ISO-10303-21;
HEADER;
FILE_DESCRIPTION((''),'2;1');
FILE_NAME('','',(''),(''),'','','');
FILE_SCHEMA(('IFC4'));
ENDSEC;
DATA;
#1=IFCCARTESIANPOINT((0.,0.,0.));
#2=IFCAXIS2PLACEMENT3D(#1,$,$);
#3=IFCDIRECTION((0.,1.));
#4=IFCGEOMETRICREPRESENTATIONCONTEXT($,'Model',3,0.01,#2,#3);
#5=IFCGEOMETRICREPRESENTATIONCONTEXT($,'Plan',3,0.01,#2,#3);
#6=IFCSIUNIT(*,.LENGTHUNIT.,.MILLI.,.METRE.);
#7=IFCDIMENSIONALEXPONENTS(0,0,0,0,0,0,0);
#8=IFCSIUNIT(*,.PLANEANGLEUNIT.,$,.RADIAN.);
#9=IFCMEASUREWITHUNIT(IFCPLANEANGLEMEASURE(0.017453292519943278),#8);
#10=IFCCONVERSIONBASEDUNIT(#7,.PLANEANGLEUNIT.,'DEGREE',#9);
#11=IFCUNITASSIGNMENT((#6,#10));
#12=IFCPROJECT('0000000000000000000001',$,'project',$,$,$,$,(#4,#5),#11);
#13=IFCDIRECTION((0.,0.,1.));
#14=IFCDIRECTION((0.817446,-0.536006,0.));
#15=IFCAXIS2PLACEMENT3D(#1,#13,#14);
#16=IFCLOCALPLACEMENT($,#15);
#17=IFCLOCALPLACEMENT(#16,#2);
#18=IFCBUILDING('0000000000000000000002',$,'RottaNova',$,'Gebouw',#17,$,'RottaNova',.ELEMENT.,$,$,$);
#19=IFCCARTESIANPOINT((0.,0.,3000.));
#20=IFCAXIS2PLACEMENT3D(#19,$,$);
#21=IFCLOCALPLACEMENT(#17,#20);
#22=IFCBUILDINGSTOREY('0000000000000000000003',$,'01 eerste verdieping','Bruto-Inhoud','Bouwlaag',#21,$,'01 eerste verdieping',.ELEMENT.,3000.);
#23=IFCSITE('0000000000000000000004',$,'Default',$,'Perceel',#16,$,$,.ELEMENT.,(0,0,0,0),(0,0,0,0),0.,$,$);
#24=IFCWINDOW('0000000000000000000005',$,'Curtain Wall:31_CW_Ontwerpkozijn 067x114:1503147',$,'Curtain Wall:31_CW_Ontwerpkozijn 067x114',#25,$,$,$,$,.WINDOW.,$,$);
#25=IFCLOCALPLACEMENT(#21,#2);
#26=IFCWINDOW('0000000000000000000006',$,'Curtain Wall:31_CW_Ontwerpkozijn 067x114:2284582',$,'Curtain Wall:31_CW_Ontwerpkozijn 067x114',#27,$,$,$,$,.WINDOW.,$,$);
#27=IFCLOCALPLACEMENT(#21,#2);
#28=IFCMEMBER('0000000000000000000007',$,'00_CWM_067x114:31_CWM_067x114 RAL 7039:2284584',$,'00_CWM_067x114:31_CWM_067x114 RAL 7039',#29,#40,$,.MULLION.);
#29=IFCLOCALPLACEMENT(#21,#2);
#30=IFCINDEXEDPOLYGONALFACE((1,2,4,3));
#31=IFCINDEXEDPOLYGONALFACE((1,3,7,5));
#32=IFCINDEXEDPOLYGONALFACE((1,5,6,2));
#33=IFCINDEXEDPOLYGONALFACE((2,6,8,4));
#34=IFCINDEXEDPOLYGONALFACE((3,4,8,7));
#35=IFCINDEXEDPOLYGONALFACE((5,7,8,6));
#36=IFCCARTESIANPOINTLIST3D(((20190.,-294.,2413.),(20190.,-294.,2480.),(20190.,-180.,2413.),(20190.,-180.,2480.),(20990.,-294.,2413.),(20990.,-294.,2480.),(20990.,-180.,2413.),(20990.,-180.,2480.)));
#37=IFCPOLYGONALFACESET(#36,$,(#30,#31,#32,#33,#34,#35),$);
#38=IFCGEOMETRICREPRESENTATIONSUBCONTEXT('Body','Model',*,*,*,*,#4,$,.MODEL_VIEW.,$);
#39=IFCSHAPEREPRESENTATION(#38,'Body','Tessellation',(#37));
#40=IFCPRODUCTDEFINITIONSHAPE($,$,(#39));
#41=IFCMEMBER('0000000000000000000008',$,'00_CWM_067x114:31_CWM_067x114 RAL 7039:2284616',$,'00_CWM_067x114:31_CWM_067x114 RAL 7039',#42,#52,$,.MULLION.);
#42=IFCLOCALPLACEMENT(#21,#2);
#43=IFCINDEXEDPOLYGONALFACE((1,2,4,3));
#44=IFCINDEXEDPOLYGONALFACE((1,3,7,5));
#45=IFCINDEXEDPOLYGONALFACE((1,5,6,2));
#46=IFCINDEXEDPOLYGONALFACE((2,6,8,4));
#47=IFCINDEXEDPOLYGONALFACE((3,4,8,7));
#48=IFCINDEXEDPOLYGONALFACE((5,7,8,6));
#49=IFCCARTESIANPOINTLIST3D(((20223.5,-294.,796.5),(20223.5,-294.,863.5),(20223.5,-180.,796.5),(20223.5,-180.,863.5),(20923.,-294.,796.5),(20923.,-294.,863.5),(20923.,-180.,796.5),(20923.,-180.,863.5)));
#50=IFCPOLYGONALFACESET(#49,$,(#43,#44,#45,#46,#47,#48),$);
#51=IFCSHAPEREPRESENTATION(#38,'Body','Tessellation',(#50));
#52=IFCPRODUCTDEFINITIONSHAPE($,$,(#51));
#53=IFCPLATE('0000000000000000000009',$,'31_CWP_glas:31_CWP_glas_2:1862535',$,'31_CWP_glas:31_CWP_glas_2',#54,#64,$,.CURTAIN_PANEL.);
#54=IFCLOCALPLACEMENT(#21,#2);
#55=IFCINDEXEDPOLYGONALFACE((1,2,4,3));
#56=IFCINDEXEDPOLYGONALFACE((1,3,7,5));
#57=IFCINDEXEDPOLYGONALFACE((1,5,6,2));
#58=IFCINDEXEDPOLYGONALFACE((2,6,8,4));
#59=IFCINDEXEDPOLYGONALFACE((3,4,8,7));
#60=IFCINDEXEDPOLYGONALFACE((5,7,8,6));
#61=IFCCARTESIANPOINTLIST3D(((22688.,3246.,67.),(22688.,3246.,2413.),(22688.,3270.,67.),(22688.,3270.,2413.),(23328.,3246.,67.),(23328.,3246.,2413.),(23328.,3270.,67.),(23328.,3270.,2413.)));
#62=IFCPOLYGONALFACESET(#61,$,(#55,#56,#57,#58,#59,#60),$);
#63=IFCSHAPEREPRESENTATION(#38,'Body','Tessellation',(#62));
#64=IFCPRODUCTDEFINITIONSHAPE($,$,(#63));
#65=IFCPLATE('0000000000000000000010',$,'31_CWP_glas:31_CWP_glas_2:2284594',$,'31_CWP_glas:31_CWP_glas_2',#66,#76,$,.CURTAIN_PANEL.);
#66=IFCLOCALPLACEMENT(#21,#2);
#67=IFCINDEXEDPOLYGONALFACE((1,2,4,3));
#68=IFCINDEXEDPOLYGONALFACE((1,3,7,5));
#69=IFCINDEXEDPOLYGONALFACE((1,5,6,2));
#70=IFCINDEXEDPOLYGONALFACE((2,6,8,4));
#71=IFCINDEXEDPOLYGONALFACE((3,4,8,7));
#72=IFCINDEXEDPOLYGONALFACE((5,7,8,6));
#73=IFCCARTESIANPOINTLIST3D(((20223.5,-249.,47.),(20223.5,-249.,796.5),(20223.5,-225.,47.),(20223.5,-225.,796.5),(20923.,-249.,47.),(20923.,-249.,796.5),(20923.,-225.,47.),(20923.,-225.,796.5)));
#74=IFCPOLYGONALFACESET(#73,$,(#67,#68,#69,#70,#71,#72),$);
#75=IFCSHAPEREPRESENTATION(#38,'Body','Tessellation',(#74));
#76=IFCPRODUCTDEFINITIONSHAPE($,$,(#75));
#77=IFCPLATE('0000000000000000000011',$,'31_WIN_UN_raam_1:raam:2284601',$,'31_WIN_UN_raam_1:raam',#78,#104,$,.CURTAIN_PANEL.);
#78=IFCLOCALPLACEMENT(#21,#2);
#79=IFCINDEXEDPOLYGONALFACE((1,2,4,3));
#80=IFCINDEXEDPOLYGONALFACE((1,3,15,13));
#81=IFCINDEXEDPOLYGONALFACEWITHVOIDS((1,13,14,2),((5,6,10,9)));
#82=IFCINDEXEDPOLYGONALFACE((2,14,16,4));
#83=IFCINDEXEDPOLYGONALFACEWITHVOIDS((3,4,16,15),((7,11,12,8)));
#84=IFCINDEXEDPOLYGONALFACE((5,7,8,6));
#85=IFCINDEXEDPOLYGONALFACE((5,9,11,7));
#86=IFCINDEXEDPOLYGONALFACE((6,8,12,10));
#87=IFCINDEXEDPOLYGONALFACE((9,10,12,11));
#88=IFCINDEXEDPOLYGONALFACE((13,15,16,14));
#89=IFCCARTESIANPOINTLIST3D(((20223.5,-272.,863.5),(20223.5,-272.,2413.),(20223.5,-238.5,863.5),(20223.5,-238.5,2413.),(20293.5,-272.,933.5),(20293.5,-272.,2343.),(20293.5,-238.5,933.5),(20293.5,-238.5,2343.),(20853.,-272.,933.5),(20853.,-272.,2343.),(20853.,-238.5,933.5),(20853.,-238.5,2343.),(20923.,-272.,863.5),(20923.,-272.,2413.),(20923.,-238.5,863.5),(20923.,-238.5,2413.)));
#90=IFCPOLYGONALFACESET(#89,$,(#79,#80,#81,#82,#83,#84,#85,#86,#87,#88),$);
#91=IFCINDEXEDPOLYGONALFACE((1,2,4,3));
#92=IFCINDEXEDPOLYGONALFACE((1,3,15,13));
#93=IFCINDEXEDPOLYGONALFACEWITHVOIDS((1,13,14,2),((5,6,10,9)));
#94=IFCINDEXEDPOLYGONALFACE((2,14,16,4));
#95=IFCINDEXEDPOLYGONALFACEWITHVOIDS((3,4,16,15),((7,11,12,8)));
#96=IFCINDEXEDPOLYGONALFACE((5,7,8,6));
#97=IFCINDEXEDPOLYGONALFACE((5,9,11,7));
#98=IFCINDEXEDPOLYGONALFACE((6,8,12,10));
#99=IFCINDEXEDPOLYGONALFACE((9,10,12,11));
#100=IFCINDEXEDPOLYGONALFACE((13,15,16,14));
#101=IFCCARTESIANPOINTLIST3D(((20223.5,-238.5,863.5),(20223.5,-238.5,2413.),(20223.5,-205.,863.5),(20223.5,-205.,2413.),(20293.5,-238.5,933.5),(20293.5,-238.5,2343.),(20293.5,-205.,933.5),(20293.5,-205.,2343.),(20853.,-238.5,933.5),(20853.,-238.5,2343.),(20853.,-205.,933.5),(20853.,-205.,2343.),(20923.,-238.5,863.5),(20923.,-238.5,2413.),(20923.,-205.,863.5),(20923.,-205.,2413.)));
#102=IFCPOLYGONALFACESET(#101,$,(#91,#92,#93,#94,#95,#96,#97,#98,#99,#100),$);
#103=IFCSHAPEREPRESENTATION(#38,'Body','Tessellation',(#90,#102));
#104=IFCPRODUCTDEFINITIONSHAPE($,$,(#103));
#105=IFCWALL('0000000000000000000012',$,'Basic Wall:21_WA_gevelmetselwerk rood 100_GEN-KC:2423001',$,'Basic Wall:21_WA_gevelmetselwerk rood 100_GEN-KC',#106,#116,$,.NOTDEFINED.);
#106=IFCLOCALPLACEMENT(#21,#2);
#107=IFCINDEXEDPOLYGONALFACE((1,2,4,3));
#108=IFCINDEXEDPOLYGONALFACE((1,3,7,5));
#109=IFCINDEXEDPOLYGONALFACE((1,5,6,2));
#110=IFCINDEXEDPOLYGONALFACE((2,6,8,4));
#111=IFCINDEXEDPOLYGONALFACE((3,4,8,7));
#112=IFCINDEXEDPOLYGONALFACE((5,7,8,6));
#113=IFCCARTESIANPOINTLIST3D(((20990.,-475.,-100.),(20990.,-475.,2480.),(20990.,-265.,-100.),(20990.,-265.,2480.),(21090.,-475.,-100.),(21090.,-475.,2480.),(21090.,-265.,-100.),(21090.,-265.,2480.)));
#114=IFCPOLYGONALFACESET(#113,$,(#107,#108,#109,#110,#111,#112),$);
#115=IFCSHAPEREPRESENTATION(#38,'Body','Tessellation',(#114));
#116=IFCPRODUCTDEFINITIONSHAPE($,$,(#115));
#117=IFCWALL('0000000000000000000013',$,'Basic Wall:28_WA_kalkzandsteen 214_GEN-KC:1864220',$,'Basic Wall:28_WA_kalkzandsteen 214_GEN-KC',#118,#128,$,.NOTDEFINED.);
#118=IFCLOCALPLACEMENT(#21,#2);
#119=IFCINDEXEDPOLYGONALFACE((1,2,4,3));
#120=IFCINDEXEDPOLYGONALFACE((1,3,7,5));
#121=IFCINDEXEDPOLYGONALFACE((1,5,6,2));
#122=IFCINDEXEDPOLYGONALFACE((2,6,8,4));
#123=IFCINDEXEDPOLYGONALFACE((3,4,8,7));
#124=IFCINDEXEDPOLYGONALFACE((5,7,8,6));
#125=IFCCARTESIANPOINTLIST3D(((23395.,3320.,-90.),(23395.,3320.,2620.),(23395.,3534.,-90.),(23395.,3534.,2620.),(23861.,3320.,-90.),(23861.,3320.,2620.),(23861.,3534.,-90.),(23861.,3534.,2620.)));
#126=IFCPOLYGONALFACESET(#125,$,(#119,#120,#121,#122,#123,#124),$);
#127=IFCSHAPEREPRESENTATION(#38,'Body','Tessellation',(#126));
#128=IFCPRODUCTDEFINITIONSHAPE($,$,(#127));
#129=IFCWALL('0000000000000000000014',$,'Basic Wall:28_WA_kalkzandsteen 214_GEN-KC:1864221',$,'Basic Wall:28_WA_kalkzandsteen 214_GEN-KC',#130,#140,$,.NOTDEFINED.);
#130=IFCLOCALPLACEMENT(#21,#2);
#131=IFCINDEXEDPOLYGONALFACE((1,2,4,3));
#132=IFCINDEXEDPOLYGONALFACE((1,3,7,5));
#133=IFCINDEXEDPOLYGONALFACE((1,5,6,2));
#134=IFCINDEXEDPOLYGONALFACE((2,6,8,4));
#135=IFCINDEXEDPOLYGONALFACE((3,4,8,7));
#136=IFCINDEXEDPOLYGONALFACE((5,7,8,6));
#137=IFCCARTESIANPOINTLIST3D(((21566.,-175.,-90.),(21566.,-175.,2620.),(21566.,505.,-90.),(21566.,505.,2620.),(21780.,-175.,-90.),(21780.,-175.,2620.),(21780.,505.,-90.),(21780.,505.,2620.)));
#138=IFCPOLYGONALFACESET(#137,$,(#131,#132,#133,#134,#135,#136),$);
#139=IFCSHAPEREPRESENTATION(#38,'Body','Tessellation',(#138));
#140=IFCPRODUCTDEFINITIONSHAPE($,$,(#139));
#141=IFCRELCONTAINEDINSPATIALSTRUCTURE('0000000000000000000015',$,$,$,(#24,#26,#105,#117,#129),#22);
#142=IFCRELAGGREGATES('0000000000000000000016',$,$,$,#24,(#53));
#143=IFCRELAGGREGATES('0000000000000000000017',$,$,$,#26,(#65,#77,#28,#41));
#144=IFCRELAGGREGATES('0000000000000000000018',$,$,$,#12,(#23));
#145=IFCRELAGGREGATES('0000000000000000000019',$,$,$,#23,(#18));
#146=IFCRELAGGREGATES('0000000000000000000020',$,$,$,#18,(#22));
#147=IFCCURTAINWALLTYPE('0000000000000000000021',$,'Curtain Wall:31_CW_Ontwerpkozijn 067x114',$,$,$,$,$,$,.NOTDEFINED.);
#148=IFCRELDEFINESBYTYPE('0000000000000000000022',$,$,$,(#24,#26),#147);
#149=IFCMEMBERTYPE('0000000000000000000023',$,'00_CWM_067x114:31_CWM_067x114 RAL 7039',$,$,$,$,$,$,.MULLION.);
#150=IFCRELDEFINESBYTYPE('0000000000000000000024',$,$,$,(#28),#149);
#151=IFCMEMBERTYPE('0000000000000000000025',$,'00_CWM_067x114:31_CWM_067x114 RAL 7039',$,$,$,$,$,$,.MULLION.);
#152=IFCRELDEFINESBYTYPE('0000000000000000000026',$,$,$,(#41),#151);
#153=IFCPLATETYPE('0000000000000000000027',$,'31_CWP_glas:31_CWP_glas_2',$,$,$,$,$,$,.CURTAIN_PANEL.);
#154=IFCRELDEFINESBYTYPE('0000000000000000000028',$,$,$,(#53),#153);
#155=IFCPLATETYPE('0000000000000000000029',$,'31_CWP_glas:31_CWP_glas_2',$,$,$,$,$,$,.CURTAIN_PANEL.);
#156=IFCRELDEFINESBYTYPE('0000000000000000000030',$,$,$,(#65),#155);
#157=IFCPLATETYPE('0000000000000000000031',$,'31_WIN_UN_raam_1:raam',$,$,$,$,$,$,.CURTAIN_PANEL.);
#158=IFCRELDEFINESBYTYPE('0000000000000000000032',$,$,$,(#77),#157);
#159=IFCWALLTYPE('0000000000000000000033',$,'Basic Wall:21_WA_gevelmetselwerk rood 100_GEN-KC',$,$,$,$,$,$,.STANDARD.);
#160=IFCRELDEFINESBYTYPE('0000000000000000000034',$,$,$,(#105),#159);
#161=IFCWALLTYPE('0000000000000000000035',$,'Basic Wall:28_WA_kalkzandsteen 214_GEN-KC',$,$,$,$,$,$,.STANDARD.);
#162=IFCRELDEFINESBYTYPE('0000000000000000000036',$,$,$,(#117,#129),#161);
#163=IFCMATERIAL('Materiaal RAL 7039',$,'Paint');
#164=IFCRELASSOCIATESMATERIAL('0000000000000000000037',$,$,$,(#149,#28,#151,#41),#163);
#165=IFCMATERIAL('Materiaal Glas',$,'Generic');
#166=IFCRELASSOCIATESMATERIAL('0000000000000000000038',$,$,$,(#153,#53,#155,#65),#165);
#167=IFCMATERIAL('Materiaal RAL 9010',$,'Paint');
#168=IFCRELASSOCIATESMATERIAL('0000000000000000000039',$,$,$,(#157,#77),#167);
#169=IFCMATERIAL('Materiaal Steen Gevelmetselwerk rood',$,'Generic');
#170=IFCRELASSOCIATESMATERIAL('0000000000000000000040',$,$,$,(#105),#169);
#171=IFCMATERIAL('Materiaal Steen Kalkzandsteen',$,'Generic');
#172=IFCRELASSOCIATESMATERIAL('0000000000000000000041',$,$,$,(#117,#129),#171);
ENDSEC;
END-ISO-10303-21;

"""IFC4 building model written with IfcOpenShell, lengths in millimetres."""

from ifc_helpers import new_model, entity, si_unit, converted_unit, direction, frame, origin, place, context, subcontext, project, spatial, indexed_curve, outline, extrude, source, transform, mapped, material, type_object, type_shapes, element, aggregate, save


model = new_model("IFC4")

# Units and contexts
model_context = context("Model", 3, precision=0.01, world=origin(), true_north=direction((0.0, 1.0)))
plan_context = context("Plan", 3, precision=0.01, world=origin(), true_north=direction((0.0, 1.0)))
body_context = subcontext(model_context, "Body", "Model", "MODEL_VIEW")
ifc_project = project(units=[si_unit("LENGTHUNIT", "METRE", prefix="MILLI"), converted_unit("PLANEANGLEUNIT", "DEGREE", entity("IfcPlaneAngleMeasure", 0.017453292519943278), si_unit("PLANEANGLEUNIT", "RADIAN"), dimensions=[0, 0, 0, 0, 0, 0, 0])], contexts=[model_context, plan_context])

# Site, building, storey
site_placement = place(None, frame((0.0, 0.0, 0.0), z_axis=(0.0, 0.0, 1.0), x_axis=(0.817446, -0.536006, 0.0)))
site = spatial("IfcSite", under=ifc_project, at=site_placement, Name="Default", ObjectType="Perceel", CompositionType="ELEMENT", RefLatitude=(0, 0, 0, 0), RefLongitude=(0, 0, 0, 0), RefElevation=0.0)
building_placement = place(site_placement, origin())
building = spatial("IfcBuilding", under=site, at=building_placement, Name="RottaNova", ObjectType="Gebouw", LongName="RottaNova", CompositionType="ELEMENT")
storey_placement = place(building_placement, frame((0.0, 0.0, 3000.0)))
storey = spatial("IfcBuildingStorey", under=building, at=storey_placement, Name="01 eerste verdieping", Description="Bruto-Inhoud", ObjectType="Bouwlaag", LongName="01 eerste verdieping", CompositionType="ELEMENT", Elevation=3000.0)

# Windows, members
curtain_wall_type = type_object("IfcCurtainWallType", Name="Curtain Wall:31_CW_Ontwerpkozijn 067x114", PredefinedType="NOTDEFINED")
ifc_material_1 = material(Name="Materiaal RAL 7039", Category="Paint")
window_1_placement = place(storey_placement, frame((0.0, 0.0, -3000.0)))
window_1 = element("IfcWindow", 1, at=window_1_placement, inside=storey, type_object=curtain_wall_type, Name="Curtain Wall:31_CW_Ontwerpkozijn 067x114:1503147", ObjectType="Curtain Wall:31_CW_Ontwerpkozijn 067x114", PredefinedType="WINDOW")
window_2_placement = place(storey_placement, frame((0.0, 0.0, -3000.0)))
window_2 = element("IfcWindow", 2, at=window_2_placement, inside=storey, type_object=curtain_wall_type, Name="Curtain Wall:31_CW_Ontwerpkozijn 067x114:2284582", ObjectType="Curtain Wall:31_CW_Ontwerpkozijn 067x114", PredefinedType="WINDOW")
member_type_1 = type_object("IfcMemberType", Name="00_CWM_067x114:31_CWM_067x114 RAL 7039", PredefinedType="MULLION", material=ifc_material_1)
shared_shape_1 = source(origin(), body_context, "Body", "SweptSolid", [
    extrude(outline(indexed_curve([(-33.5, -57.0), (33.5, -57.0), (33.5, 57.0), (-33.5, 57.0), (-33.5, -57.0)], self_intersect=False)), frame((-33.5, 57.0, -800.0), z_axis=(0.0, 0.0, 1.0), x_axis=(-1.0, 0.0, 0.0)), (0.0, 0.0, 1.0), 800.0),
])
type_shapes(member_type_1, [shared_shape_1])
member_1_placement = place(window_2_placement, frame((20990.0, -180.0, 5480.0), z_axis=(1.0, 0.0, 0.0), x_axis=(0.0, 0.0, 1.0)))
member_1 = element("IfcMember", 3, at=member_1_placement, type_object=member_type_1, material=ifc_material_1, Name="00_CWM_067x114:31_CWM_067x114 RAL 7039:2284584", ObjectType="00_CWM_067x114:31_CWM_067x114 RAL 7039", PredefinedType="MULLION", context=body_context, shape_type="MappedRepresentation", body=[
    mapped(shared_shape_1, transform((0.0, 0.0, 0.0), scale=1.0)),
])
member_type_2 = type_object("IfcMemberType", Name="00_CWM_067x114:31_CWM_067x114 RAL 7039", PredefinedType="MULLION", material=ifc_material_1)
shared_shape_2 = source(origin(), body_context, "Body", "SweptSolid", [
    extrude(outline(indexed_curve([(-33.5, -57.0), (33.5, -57.0), (33.5, 57.0), (-33.5, 57.0), (-33.5, -57.0)], self_intersect=False)), frame((0.0, 57.0, -699.5), z_axis=(0.0, 0.0, 1.0), x_axis=(-1.0, 0.0, 0.0)), (0.0, 0.0, 1.0), 699.5),
])
type_shapes(member_type_2, [shared_shape_2])
member_2_placement = place(window_2_placement, frame((20923.0, -180.0, 3830.0), z_axis=(1.0, 0.0, 0.0), x_axis=(0.0, 0.0, 1.0)))
member_2 = element("IfcMember", 4, at=member_2_placement, type_object=member_type_2, material=ifc_material_1, Name="00_CWM_067x114:31_CWM_067x114 RAL 7039:2284616", ObjectType="00_CWM_067x114:31_CWM_067x114 RAL 7039", PredefinedType="MULLION", context=body_context, shape_type="MappedRepresentation", body=[
    mapped(shared_shape_2, transform((0.0, 0.0, 0.0), scale=1.0)),
])

# Plates
ifc_material_2 = material(Name="Materiaal Glas", Category="Generic")
plate_type_1 = type_object("IfcPlateType", Name="31_CWP_glas:31_CWP_glas_2", PredefinedType="CURTAIN_PANEL", material=ifc_material_2)
shared_shape_3 = source(origin(), body_context, "Body", "SweptSolid", [
    extrude(outline(indexed_curve([(-12.0, -320.0), (12.0, -320.0), (12.0, 320.0), (-12.0, 320.0), (-12.0, -320.0)], self_intersect=False)), frame((0.0, -57.0, 0.0), z_axis=(0.0, 0.0, 1.0), x_axis=(0.0, 1.0, 0.0)), (0.0, 0.0, 1.0), 2346.0),
])
type_shapes(plate_type_1, [shared_shape_3])
plate_1_placement = place(window_1_placement, frame((23008.0, 3315.0, 3067.0)))
plate_1 = element("IfcPlate", 5, at=plate_1_placement, type_object=plate_type_1, material=ifc_material_2, Name="31_CWP_glas:31_CWP_glas_2:1862535", ObjectType="31_CWP_glas:31_CWP_glas_2", PredefinedType="CURTAIN_PANEL", context=body_context, shape_type="MappedRepresentation", body=[
    mapped(shared_shape_3, transform((0.0, 0.0, 0.0), scale=1.0)),
])
aggregate(window_1, [plate_1])
plate_type_2 = type_object("IfcPlateType", Name="31_CWP_glas:31_CWP_glas_2", PredefinedType="CURTAIN_PANEL", material=ifc_material_2)
shared_shape_4 = source(origin(), body_context, "Body", "SweptSolid", [
    extrude(outline(indexed_curve([(-12.0, -349.7), (12.0, -349.7), (12.0, 349.7), (-12.0, 349.7), (-12.0, -349.7)], self_intersect=False)), frame((0.0, -57.0, 0.0), z_axis=(0.0, 0.0, 1.0), x_axis=(0.0, 1.0, 0.0)), (0.0, 0.0, 1.0), 749.5),
])
type_shapes(plate_type_2, [shared_shape_4])
plate_2_placement = place(window_2_placement, frame((20573.3, -180.0, 3047.0)))
plate_2 = element("IfcPlate", 6, at=plate_2_placement, type_object=plate_type_2, material=ifc_material_2, Name="31_CWP_glas:31_CWP_glas_2:2284594", ObjectType="31_CWP_glas:31_CWP_glas_2", PredefinedType="CURTAIN_PANEL", context=body_context, shape_type="MappedRepresentation", body=[
    mapped(shared_shape_4, transform((0.0, 0.0, 0.0), scale=1.0)),
])
ifc_material_3 = material(Name="Materiaal RAL 9010", Category="Paint")
plate_type_3 = type_object("IfcPlateType", Name="31_WIN_UN_raam_1:raam", PredefinedType="CURTAIN_PANEL", material=ifc_material_3)
shared_shape_5 = source(origin(), body_context, "Body", "SweptSolid", [
    extrude(outline(indexed_curve([(-349.7, -774.8), (349.7, -774.8), (349.7, 774.8), (-349.7, 774.8), (-349.7, -774.8)], self_intersect=False), holes=[indexed_curve([(-279.7, 704.8), (279.7, 704.8), (279.7, -704.8), (-279.7, -704.8), (-279.7, 704.8)], self_intersect=False)]), frame((0.0, -92.0, 774.8), z_axis=(0.0, 1.0, 0.0), x_axis=(1.0, 0.0, 0.0)), (0.0, 0.0, 1.0), 33.5),
    extrude(outline(indexed_curve([(-349.7, -774.8), (349.7, -774.8), (349.7, 774.8), (-349.7, 774.8), (-349.7, -774.8)], self_intersect=False), holes=[indexed_curve([(-279.7, 704.7), (279.7, 704.7), (279.7, -704.8), (-279.7, -704.8), (-279.7, 704.7)], self_intersect=False)]), frame((0.0, -58.5, 774.8), z_axis=(0.0, 1.0, 0.0), x_axis=(1.0, 0.0, 0.0)), (0.0, 0.0, 1.0), 33.5),
])
type_shapes(plate_type_3, [shared_shape_5])
plate_3_placement = place(window_2_placement, frame((20573.3, -180.0, 3863.5)))
plate_3 = element("IfcPlate", 7, at=plate_3_placement, type_object=plate_type_3, material=ifc_material_3, Name="31_WIN_UN_raam_1:raam:2284601", ObjectType="31_WIN_UN_raam_1:raam", PredefinedType="CURTAIN_PANEL", context=body_context, shape_type="MappedRepresentation", body=[
    mapped(shared_shape_5, transform((0.0, 0.0, 0.0), scale=1.0)),
])
aggregate(window_2, [plate_2, plate_3, member_1, member_2])

# Walls
ifc_material_4 = material(Name="Materiaal Steen Gevelmetselwerk rood", Category="Generic")
wall_type_1 = type_object("IfcWallType", Name="Basic Wall:21_WA_gevelmetselwerk rood 100_GEN-KC", PredefinedType="STANDARD")
wall_1_placement = place(storey_placement, frame((21040.0, -265.0, -100.0), z_axis=(0.0, 0.0, 1.0), x_axis=(0.0, -1.0, 0.0)))
element("IfcWall", 8, at=wall_1_placement, inside=storey, type_object=wall_type_1, material=ifc_material_4, Name="Basic Wall:21_WA_gevelmetselwerk rood 100_GEN-KC:2423001", ObjectType="Basic Wall:21_WA_gevelmetselwerk rood 100_GEN-KC", PredefinedType="NOTDEFINED", context=body_context, shape_type="SweptSolid", body=[
    extrude(outline(indexed_curve([(210.0, 50.0), (0.0, 50.0), (0.0, -50.0), (210.0, -50.0), (210.0, 50.0)], self_intersect=False)), origin(), (0.0, 0.0, 1.0), 2580.0),
])
ifc_material_5 = material(Name="Materiaal Steen Kalkzandsteen", Category="Generic")
wall_type_2 = type_object("IfcWallType", Name="Basic Wall:28_WA_kalkzandsteen 214_GEN-KC", PredefinedType="STANDARD")
wall_2_placement = place(storey_placement, frame((23861.0, 3427.0, -90.0), z_axis=(0.0, 0.0, 1.0), x_axis=(-1.0, 0.0, 0.0)))
element("IfcWall", 9, at=wall_2_placement, inside=storey, type_object=wall_type_2, material=ifc_material_5, Name="Basic Wall:28_WA_kalkzandsteen 214_GEN-KC:1864220", ObjectType="Basic Wall:28_WA_kalkzandsteen 214_GEN-KC", PredefinedType="NOTDEFINED", context=body_context, shape_type="SweptSolid", body=[
    extrude(outline(indexed_curve([(466.0, 107.0), (0.0, 107.0), (0.0, -107.0), (466.0, -107.0), (466.0, 107.0)], self_intersect=False)), origin(), (0.0, 0.0, 1.0), 2710.0),
])
wall_3_placement = place(storey_placement, frame((21673.0, -175.0, -90.0), z_axis=(0.0, 0.0, 1.0), x_axis=(0.0, 1.0, 0.0)))
element("IfcWall", 10, at=wall_3_placement, inside=storey, type_object=wall_type_2, material=ifc_material_5, Name="Basic Wall:28_WA_kalkzandsteen 214_GEN-KC:1864221", ObjectType="Basic Wall:28_WA_kalkzandsteen 214_GEN-KC", PredefinedType="NOTDEFINED", context=body_context, shape_type="SweptSolid", body=[
    extrude(outline(indexed_curve([(680.0, 107.0), (0.0, 107.0), (0.0, -107.0), (680.0, -107.0), (680.0, 107.0)], self_intersect=False)), origin(), (0.0, 0.0, 1.0), 2710.0),
])

save(model, "model.ifc")
